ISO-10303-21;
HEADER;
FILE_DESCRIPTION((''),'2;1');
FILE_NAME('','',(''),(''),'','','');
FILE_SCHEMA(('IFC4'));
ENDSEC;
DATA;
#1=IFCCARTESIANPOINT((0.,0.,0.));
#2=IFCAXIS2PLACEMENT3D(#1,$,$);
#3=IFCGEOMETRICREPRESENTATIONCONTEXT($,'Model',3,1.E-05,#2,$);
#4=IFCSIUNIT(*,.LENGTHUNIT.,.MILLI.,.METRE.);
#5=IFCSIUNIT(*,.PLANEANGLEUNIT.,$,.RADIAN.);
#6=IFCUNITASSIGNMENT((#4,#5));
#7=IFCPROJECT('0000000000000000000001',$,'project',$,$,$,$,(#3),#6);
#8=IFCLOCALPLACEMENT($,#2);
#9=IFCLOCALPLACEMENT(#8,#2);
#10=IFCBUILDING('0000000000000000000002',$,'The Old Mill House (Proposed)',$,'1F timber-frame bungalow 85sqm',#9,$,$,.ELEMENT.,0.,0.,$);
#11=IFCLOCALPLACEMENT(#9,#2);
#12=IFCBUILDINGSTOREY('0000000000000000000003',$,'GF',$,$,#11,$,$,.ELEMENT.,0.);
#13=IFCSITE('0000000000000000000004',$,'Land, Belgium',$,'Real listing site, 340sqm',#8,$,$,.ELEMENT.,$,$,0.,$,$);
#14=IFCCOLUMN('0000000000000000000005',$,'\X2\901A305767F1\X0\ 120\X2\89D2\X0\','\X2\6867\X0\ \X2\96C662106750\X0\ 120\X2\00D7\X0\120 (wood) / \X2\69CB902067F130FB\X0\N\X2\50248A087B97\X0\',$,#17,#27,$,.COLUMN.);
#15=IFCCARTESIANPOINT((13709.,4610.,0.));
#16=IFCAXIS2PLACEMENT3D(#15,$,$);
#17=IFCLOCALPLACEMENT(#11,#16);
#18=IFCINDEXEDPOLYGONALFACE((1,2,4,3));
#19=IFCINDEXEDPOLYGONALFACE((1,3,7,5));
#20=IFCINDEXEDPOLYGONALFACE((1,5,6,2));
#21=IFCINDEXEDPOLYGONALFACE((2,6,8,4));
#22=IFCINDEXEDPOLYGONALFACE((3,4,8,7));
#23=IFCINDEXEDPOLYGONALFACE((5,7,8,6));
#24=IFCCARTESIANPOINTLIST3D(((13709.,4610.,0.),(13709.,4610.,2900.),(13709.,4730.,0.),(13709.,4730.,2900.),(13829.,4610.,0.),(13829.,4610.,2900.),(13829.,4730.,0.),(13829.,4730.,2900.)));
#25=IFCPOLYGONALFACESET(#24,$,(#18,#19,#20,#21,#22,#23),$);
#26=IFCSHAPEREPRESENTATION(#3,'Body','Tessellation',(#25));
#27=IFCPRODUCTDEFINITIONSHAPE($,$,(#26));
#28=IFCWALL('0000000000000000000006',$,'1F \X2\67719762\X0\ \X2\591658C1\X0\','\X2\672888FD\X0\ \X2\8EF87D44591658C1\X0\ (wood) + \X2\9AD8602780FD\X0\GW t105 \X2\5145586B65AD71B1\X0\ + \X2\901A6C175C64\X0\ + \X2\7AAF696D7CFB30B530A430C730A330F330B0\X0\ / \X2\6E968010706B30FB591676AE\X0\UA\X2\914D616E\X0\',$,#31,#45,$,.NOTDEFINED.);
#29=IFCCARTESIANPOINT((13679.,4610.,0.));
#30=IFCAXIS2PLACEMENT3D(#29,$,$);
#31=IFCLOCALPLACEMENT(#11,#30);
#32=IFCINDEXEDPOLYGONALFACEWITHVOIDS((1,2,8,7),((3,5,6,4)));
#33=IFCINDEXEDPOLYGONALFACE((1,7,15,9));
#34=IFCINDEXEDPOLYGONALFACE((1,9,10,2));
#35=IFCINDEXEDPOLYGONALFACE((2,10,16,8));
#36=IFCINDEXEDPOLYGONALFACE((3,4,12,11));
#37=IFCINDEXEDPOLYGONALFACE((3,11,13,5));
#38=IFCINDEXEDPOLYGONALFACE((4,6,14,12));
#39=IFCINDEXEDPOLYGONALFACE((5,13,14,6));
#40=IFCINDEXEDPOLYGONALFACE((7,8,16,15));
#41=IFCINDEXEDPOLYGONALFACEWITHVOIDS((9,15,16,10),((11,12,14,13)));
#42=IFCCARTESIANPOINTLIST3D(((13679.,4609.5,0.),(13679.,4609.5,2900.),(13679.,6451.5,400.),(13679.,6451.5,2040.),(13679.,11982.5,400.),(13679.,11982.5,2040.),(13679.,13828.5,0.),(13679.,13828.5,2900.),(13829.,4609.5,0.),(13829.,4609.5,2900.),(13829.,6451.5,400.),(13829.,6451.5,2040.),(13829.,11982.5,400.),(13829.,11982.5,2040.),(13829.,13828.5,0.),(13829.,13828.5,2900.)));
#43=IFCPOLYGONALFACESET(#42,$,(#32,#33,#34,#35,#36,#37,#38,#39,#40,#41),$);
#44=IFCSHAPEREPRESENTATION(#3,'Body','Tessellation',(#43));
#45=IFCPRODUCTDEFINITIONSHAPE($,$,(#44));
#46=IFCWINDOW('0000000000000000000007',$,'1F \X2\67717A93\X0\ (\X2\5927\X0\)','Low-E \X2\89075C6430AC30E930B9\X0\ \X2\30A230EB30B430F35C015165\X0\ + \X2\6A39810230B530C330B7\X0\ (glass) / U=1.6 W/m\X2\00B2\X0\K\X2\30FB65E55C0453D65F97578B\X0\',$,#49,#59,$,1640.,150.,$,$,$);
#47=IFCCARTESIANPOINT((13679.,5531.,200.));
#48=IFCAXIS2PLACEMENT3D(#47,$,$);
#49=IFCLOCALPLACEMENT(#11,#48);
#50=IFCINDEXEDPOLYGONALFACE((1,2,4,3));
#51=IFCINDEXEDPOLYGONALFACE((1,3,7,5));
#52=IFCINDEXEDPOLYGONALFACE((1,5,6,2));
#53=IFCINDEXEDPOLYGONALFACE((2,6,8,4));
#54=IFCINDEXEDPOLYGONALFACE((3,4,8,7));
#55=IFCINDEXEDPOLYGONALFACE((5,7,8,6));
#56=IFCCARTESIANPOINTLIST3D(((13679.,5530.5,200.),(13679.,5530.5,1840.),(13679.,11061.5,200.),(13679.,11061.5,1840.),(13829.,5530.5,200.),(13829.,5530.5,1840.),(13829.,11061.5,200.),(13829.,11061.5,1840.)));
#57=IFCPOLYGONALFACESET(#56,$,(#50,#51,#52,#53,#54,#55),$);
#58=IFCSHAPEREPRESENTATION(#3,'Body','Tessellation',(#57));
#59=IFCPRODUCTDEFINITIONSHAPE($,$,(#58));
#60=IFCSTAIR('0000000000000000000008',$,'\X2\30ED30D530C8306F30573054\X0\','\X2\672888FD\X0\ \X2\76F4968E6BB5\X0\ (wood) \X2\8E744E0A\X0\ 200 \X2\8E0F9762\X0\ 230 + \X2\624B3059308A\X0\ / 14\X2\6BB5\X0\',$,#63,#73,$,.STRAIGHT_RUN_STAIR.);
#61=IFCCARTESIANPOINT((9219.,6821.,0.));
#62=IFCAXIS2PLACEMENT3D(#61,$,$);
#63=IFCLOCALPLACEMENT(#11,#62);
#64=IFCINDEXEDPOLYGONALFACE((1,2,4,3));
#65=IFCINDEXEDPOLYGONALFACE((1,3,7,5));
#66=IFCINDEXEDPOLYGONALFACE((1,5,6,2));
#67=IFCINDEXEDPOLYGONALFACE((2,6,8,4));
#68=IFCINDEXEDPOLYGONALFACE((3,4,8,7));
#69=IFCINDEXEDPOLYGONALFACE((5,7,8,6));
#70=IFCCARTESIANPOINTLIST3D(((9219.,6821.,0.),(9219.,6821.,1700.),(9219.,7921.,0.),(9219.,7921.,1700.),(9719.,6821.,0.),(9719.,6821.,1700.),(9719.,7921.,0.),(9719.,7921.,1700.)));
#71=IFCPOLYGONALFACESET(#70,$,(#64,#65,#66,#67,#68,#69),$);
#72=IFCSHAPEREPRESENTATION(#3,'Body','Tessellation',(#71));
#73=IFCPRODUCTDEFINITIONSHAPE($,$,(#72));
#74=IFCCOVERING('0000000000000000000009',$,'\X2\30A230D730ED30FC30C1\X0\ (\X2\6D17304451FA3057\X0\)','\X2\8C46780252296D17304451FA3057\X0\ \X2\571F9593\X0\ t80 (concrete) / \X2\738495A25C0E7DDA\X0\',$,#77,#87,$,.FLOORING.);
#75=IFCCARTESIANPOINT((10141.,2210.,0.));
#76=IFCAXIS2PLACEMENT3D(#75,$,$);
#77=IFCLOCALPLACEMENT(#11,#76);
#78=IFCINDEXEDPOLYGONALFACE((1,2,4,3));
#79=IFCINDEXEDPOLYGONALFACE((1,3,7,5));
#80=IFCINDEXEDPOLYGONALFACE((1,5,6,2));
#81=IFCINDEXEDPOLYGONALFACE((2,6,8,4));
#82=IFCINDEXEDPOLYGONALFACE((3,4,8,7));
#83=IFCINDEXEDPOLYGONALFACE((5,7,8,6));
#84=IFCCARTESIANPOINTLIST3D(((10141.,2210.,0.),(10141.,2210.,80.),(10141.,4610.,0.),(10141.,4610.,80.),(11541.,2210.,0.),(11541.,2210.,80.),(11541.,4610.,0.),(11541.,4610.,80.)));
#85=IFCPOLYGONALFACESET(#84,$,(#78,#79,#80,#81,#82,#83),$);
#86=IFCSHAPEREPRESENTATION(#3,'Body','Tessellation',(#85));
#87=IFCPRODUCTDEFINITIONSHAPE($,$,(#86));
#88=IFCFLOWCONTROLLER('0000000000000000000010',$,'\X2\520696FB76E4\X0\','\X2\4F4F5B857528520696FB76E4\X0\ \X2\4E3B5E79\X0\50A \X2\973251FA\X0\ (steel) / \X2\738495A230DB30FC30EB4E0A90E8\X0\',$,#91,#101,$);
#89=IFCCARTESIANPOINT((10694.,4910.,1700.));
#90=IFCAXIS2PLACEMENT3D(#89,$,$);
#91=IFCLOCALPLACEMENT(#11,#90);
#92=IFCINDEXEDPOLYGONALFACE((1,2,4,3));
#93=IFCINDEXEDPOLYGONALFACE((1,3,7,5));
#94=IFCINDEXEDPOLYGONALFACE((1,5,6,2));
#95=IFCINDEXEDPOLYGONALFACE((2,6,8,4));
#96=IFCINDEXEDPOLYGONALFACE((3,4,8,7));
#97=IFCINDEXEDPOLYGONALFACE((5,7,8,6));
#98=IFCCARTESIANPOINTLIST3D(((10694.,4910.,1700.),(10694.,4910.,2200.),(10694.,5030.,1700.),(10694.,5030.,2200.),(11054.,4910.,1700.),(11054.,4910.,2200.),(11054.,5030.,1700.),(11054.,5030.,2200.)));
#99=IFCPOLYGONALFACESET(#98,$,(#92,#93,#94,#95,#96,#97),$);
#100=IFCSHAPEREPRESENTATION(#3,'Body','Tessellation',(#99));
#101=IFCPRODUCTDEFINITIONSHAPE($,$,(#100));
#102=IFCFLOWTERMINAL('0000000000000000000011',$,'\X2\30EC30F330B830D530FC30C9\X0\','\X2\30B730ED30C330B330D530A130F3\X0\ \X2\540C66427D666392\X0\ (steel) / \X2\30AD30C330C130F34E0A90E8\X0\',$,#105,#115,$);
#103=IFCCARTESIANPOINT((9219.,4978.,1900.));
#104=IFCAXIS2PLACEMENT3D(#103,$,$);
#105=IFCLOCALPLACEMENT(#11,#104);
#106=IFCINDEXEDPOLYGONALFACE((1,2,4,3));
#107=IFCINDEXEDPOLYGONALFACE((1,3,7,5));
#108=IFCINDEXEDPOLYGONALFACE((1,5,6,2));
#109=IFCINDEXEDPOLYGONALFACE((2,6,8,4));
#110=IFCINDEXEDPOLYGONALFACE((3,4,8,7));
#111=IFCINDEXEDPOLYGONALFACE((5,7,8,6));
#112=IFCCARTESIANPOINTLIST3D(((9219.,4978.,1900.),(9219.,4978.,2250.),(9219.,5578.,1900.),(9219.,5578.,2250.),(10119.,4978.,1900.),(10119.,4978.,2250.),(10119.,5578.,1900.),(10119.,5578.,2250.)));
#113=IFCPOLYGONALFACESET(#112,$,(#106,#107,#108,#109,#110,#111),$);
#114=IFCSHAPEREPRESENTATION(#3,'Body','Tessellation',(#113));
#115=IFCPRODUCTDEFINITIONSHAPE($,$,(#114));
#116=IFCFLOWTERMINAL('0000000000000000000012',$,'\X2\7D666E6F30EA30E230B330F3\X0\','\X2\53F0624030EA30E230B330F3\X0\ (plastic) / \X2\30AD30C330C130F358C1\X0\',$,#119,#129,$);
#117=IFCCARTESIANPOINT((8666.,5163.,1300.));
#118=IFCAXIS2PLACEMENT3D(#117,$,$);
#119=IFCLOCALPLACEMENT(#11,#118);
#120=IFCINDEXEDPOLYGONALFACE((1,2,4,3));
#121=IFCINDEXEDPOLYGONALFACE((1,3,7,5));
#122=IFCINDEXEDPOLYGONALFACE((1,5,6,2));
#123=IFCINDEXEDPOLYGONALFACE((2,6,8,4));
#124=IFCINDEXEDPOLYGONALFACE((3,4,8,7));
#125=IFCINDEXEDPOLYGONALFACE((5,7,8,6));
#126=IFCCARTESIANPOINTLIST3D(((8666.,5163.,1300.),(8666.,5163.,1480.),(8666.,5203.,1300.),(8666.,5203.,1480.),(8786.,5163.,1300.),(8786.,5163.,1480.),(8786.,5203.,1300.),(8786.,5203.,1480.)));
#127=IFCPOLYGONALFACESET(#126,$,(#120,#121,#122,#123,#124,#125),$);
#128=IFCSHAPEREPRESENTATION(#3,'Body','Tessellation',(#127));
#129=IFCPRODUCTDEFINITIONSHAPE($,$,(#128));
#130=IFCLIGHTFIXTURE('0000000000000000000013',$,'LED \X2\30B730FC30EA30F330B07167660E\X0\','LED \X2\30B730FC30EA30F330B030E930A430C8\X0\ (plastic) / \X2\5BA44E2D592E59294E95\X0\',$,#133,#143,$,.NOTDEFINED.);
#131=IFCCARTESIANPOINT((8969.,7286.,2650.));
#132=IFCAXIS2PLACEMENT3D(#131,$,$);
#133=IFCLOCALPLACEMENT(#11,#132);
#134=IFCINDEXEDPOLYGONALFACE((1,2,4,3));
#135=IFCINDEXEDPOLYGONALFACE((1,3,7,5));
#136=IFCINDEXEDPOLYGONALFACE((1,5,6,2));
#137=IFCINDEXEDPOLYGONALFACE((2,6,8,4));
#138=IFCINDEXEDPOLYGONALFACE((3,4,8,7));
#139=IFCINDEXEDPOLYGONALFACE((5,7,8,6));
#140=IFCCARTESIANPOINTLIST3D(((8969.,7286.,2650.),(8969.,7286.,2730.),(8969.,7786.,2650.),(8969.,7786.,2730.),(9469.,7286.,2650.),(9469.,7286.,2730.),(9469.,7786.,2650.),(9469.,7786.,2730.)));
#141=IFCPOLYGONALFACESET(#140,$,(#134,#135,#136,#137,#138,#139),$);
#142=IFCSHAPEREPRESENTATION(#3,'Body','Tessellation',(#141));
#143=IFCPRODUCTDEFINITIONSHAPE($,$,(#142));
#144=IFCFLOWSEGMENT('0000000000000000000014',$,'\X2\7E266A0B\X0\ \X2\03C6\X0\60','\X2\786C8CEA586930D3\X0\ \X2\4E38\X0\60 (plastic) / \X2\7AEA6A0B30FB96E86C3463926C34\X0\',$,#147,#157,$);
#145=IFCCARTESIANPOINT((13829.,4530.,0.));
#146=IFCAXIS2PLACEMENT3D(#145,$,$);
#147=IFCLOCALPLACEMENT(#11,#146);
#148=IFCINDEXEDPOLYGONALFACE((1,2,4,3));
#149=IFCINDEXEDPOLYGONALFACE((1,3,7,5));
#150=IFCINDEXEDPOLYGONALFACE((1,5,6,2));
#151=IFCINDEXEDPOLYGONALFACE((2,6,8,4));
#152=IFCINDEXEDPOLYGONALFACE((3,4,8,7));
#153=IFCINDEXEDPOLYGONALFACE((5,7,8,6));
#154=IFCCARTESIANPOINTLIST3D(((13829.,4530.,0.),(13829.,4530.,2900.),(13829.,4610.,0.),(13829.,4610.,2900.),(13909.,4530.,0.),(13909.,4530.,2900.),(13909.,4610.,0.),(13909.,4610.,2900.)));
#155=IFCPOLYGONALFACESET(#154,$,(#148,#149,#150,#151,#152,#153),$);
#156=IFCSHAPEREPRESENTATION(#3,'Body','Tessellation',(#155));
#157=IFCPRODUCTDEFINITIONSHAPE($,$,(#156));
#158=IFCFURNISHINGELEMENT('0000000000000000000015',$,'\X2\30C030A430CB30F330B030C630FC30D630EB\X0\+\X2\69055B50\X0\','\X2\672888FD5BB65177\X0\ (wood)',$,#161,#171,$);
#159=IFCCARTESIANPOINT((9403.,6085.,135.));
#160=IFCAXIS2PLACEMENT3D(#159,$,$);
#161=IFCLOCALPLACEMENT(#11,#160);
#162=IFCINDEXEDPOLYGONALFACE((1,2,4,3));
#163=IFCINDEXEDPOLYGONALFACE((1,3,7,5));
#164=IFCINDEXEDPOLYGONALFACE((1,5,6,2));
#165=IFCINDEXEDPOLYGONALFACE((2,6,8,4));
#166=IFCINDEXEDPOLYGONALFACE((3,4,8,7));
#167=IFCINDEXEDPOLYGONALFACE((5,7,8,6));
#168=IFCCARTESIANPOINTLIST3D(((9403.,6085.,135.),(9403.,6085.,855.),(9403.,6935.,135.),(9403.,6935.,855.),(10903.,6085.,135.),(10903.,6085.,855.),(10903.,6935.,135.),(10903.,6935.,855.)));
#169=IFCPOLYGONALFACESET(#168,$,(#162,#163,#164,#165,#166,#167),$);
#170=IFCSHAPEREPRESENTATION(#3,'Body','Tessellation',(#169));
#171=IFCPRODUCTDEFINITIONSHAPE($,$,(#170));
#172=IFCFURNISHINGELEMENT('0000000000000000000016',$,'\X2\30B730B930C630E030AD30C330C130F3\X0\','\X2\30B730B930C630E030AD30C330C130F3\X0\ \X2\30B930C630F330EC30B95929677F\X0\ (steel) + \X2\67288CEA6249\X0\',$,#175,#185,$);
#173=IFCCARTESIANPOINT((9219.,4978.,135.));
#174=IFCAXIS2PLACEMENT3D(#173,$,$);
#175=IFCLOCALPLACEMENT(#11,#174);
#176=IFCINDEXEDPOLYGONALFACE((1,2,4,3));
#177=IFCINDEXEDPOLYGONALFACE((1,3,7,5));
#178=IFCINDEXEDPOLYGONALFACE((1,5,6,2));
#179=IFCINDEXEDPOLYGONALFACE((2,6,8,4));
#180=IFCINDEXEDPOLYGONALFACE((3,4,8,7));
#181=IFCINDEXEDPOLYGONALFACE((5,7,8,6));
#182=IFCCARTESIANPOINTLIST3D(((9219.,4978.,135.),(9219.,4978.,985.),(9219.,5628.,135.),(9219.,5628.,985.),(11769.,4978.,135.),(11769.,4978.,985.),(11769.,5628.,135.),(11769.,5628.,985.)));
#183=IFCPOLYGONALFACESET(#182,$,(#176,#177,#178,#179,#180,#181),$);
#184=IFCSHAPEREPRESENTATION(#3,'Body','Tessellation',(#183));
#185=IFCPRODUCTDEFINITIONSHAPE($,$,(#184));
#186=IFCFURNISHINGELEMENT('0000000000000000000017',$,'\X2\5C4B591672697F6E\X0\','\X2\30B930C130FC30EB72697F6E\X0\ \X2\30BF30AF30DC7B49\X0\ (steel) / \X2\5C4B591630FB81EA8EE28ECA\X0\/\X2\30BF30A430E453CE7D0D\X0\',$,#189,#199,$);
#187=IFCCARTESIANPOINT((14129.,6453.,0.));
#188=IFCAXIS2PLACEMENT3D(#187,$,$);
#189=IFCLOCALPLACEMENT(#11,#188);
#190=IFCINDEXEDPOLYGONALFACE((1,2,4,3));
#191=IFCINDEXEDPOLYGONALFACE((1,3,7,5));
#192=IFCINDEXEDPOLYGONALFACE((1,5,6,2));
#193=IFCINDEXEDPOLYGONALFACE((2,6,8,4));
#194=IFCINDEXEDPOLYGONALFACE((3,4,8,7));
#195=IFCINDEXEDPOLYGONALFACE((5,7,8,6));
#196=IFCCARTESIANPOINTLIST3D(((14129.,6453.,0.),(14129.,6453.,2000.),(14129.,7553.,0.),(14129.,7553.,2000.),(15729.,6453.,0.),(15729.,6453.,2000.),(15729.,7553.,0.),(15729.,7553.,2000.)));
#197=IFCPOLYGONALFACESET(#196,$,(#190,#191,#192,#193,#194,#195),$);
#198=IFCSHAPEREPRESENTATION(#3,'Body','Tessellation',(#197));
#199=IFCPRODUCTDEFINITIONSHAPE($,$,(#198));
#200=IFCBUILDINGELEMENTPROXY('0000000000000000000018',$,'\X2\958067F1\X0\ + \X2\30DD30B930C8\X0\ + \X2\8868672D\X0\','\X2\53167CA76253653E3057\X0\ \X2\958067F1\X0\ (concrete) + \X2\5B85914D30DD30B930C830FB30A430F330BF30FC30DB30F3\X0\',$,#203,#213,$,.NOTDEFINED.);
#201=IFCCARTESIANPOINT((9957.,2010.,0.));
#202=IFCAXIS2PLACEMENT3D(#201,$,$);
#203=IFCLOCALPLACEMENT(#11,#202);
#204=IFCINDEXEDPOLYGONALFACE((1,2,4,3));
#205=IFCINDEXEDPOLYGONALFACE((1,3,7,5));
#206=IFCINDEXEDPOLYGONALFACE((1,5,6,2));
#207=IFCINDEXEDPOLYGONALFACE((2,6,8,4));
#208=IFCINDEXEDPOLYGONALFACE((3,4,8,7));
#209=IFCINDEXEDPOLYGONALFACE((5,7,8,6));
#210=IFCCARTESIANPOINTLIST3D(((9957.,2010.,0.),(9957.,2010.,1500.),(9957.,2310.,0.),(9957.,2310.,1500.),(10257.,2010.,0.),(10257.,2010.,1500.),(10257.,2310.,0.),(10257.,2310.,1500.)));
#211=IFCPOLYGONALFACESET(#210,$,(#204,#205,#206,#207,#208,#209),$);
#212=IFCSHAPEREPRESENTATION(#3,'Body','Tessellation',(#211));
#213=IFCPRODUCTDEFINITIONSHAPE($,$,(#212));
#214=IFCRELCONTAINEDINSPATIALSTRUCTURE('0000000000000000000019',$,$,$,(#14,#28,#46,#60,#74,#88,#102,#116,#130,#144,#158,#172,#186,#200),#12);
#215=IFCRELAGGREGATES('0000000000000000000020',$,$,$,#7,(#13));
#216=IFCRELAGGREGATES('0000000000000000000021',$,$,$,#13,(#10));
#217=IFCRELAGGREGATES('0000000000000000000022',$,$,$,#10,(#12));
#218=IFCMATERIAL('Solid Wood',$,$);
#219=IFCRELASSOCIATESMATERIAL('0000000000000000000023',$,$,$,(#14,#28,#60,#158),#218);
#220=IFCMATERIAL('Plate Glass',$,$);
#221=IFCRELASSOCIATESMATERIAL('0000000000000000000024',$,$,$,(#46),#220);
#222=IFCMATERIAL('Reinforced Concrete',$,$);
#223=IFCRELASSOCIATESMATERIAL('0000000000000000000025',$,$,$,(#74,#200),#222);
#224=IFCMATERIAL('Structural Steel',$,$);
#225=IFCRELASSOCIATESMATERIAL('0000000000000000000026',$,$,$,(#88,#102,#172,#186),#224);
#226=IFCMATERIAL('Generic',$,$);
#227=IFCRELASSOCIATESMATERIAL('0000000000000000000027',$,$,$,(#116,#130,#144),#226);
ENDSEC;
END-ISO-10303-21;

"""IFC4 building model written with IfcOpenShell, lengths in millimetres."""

from ifc_helpers import new_model, si_unit, frame, frame_2d, origin, place, context, project, spatial, rectangle, extrude, material, element, fill, save


model = new_model("IFC4")

# Units and contexts
model_context = context("Model", 3, precision=1e-05, world=origin())
ifc_project = project(units=[si_unit("LENGTHUNIT", "METRE", prefix="MILLI"), si_unit("PLANEANGLEUNIT", "RADIAN")], contexts=[model_context])

# Site, building, storey
site_placement = place(None, origin())
site = spatial("IfcSite", under=ifc_project, at=site_placement, Name="Land, Belgium", ObjectType="Real listing site, 340sqm", CompositionType="ELEMENT", RefElevation=0.0)
building_placement = place(site_placement, origin())
building = spatial("IfcBuilding", under=site, at=building_placement, Name="The Old Mill House (Proposed)", ObjectType="1F timber-frame bungalow 85sqm", CompositionType="ELEMENT", ElevationOfRefHeight=0.0, ElevationOfTerrain=0.0)
storey_placement = place(building_placement, origin())
storey = spatial("IfcBuildingStorey", under=building, at=storey_placement, Name="GF", CompositionType="ELEMENT", Elevation=0.0)

# Column
ifc_material_1 = material(Name="Solid Wood")
column_1_placement = place(storey_placement, frame((13709.0, 4610.0, 0.0)))
element("IfcColumn", 1, at=column_1_placement, inside=storey, material=ifc_material_1, Name="通し柱 120角", Description="桧 集成材 120×120 (wood) / 構造柱・N値計算", PredefinedType="COLUMN", context=model_context, shape_type="SweptSolid", body=[
    extrude(rectangle(XDim=120.0, YDim=120.0, at=frame_2d((60.0, 60.0))), frame((13709.0, 4610.0, 0.0)), (0.0, 0.0, 1.0), 2900.0),
])

# Wall, opening, window
wall_1_placement = place(storey_placement, frame((13679.0, 4610.0, 0.0)))
wall_1 = element("IfcWall", 2, at=wall_1_placement, inside=storey, material=ifc_material_1, Name="1F 東面 外壁", Description="木製 軸組外壁 (wood) + 高性能GW t105 充填断熱 + 通気層 + 窯業系サイディング / 準耐火・外皮UA配慮", PredefinedType="NOTDEFINED", context=model_context, shape_type="SweptSolid", body=[
    extrude(rectangle(XDim=150.0, YDim=9219.0, at=frame_2d((75.0, 4609.0))), frame((13679.0, 4610.0, 0.0)), (0.0, 0.0, 1.0), 2900.0),
])
opening_placement = place(storey_placement, frame((13679.0, 5531.0, 200.0)))
opening = element("IfcOpeningElement", 3, at=opening_placement, cuts=wall_1, PredefinedType="NOTDEFINED", context=model_context, shape_type="SweptSolid", body=[
    extrude(rectangle(XDim=150.0, YDim=5531.0, at=frame_2d((75.0, 2765.0))), frame((13679.0, 5531.0, 200.0)), (0.0, 0.0, 1.0), 1640.0),
])
ifc_material_2 = material(Name="Plate Glass")
window_placement = place(storey_placement, frame((13679.0, 5531.0, 200.0)))
window = element("IfcWindow", 4, at=window_placement, inside=storey, material=ifc_material_2, Name="1F 東窓 (大)", Description="Low-E 複層ガラス アルゴン封入 + 樹脂サッシ (glass) / U=1.6 W/m²K・日射取得型", OverallHeight=1640.0, OverallWidth=150.0, context=model_context, shape_type="SweptSolid", body=[
    extrude(rectangle(XDim=150.0, YDim=5531.0, at=frame_2d((75.0, 2765.0))), frame((13679.0, 5531.0, 200.0)), (0.0, 0.0, 1.0), 1640.0),
])
fill(opening, window)

# Stair
stair_placement = place(storey_placement, frame((9219.0, 6821.0, 0.0)))
element("IfcStair", 5, at=stair_placement, inside=storey, material=ifc_material_1, Name="ロフトはしご", Description="木製 直階段 (wood) 蹴上 200 踏面 230 + 手すり / 14段", PredefinedType="STRAIGHT_RUN_STAIR", context=model_context, shape_type="SweptSolid", body=[
    extrude(rectangle(XDim=500.0, YDim=1100.0, at=frame_2d((250.0, 550.0))), frame((9219.0, 6821.0, 0.0)), (0.0, 0.0, 1.0), 1700.0),
])

# Covering
ifc_material_3 = material(Name="Reinforced Concrete")
covering_placement = place(storey_placement, frame((10141.0, 2210.0, 0.0)))
element("IfcCovering", 6, at=covering_placement, inside=storey, material=ifc_material_3, Name="アプローチ (洗い出し)", Description="豆砂利洗い出し 土間 t80 (concrete) / 玄関導線", PredefinedType="FLOORING", context=model_context, shape_type="SweptSolid", body=[
    extrude(rectangle(XDim=1400.0, YDim=2400.0, at=frame_2d((700.0, 1200.0))), frame((10141.0, 2210.0, 0.0)), (0.0, 0.0, 1.0), 80.0),
])

# Flow controller
ifc_material_4 = material(Name="Structural Steel")
flow_controller_placement = place(storey_placement, frame((10694.0, 4910.0, 1700.0)))
element("IfcFlowController", 7, at=flow_controller_placement, inside=storey, material=ifc_material_4, Name="分電盤", Description="住宅用分電盤 主幹50A 露出 (steel) / 玄関ホール上部", context=model_context, shape_type="SweptSolid", body=[
    extrude(rectangle(XDim=360.0, YDim=120.0, at=frame_2d((180.0, 60.0))), frame((10694.0, 4910.0, 1700.0)), (0.0, 0.0, 1.0), 500.0),
])

# Flow terminals
flow_terminal_1_placement = place(storey_placement, frame((9219.0, 4978.0, 1900.0)))
element("IfcFlowTerminal", 8, at=flow_terminal_1_placement, inside=storey, material=ifc_material_4, Name="レンジフード", Description="シロッコファン 同時給排 (steel) / キッチン上部", context=model_context, shape_type="SweptSolid", body=[
    extrude(rectangle(XDim=900.0, YDim=600.0, at=frame_2d((450.0, 300.0))), frame((9219.0, 4978.0, 1900.0)), (0.0, 0.0, 1.0), 350.0),
])
ifc_material_5 = material(Name="Generic")
flow_terminal_2_placement = place(storey_placement, frame((8666.0, 5163.0, 1300.0)))
element("IfcFlowTerminal", 9, at=flow_terminal_2_placement, inside=storey, material=ifc_material_5, Name="給湯リモコン", Description="台所リモコン (plastic) / キッチン壁", context=model_context, shape_type="SweptSolid", body=[
    extrude(rectangle(XDim=120.0, YDim=40.0, at=frame_2d((60.0, 20.0))), frame((8666.0, 5163.0, 1300.0)), (0.0, 0.0, 1.0), 180.0),
])

# Light fixture
light_fixture_placement = place(storey_placement, frame((8969.0, 7286.0, 2650.0)))
element("IfcLightFixture", 10, at=light_fixture_placement, inside=storey, material=ifc_material_5, Name="LED シーリング照明", Description="LED シーリングライト (plastic) / 室中央天井", PredefinedType="NOTDEFINED", context=model_context, shape_type="SweptSolid", body=[
    extrude(rectangle(XDim=500.0, YDim=500.0, at=frame_2d((250.0, 250.0))), frame((8969.0, 7286.0, 2650.0)), (0.0, 0.0, 1.0), 80.0),
])

# Flow segment
flow_segment_placement = place(storey_placement, frame((13829.0, 4530.0, 0.0)))
element("IfcFlowSegment", 11, at=flow_segment_placement, inside=storey, material=ifc_material_5, Name="縦樋 φ60", Description="硬質塩ビ 丸60 (plastic) / 竪樋・雨水排水", context=model_context, shape_type="SweptSolid", body=[
    extrude(rectangle(XDim=80.0, YDim=80.0, at=frame_2d((40.0, 40.0))), frame((13829.0, 4530.0, 0.0)), (0.0, 0.0, 1.0), 2900.0),
])

# Furnishing elements
furnishing_1_placement = place(storey_placement, frame((9403.0, 6085.0, 135.0)))
element("IfcFurnishingElement", 12, at=furnishing_1_placement, inside=storey, material=ifc_material_1, Name="ダイニングテーブル+椅子", Description="木製家具 (wood)", context=model_context, shape_type="SweptSolid", body=[
    extrude(rectangle(XDim=1500.0, YDim=850.0, at=frame_2d((750.0, 425.0))), frame((9403.0, 6085.0, 135.0)), (0.0, 0.0, 1.0), 720.0),
])
furnishing_2_placement = place(storey_placement, frame((9219.0, 4978.0, 135.0)))
element("IfcFurnishingElement", 13, at=furnishing_2_placement, inside=storey, material=ifc_material_4, Name="システムキッチン", Description="システムキッチン ステンレス天板 (steel) + 木質扉", context=model_context, shape_type="SweptSolid", body=[
    extrude(rectangle(XDim=2550.0, YDim=650.0, at=frame_2d((1275.0, 325.0))), frame((9219.0, 4978.0, 135.0)), (0.0, 0.0, 1.0), 850.0),
])
furnishing_3_placement = place(storey_placement, frame((14129.0, 6453.0, 0.0)))
element("IfcFurnishingElement", 14, at=furnishing_3_placement, inside=storey, material=ifc_material_4, Name="屋外物置", Description="スチール物置 タクボ等 (steel) / 屋外・自転車/タイヤ収納", context=model_context, shape_type="SweptSolid", body=[
    extrude(rectangle(XDim=1600.0, YDim=1100.0, at=frame_2d((800.0, 550.0))), frame((14129.0, 6453.0, 0.0)), (0.0, 0.0, 1.0), 2000.0),
])

# Building element proxy
proxy_placement = place(storey_placement, frame((9957.0, 2010.0, 0.0)))
element("IfcBuildingElementProxy", 15, at=proxy_placement, inside=storey, material=ifc_material_3, Name="門柱 + ポスト + 表札", Description="化粧打放し 門柱 (concrete) + 宅配ポスト・インターホン", PredefinedType="NOTDEFINED", context=model_context, shape_type="SweptSolid", body=[
    extrude(rectangle(XDim=300.0, YDim=300.0, at=frame_2d((150.0, 150.0))), frame((9957.0, 2010.0, 0.0)), (0.0, 0.0, 1.0), 1500.0),
])

save(model, "model.ifc")
